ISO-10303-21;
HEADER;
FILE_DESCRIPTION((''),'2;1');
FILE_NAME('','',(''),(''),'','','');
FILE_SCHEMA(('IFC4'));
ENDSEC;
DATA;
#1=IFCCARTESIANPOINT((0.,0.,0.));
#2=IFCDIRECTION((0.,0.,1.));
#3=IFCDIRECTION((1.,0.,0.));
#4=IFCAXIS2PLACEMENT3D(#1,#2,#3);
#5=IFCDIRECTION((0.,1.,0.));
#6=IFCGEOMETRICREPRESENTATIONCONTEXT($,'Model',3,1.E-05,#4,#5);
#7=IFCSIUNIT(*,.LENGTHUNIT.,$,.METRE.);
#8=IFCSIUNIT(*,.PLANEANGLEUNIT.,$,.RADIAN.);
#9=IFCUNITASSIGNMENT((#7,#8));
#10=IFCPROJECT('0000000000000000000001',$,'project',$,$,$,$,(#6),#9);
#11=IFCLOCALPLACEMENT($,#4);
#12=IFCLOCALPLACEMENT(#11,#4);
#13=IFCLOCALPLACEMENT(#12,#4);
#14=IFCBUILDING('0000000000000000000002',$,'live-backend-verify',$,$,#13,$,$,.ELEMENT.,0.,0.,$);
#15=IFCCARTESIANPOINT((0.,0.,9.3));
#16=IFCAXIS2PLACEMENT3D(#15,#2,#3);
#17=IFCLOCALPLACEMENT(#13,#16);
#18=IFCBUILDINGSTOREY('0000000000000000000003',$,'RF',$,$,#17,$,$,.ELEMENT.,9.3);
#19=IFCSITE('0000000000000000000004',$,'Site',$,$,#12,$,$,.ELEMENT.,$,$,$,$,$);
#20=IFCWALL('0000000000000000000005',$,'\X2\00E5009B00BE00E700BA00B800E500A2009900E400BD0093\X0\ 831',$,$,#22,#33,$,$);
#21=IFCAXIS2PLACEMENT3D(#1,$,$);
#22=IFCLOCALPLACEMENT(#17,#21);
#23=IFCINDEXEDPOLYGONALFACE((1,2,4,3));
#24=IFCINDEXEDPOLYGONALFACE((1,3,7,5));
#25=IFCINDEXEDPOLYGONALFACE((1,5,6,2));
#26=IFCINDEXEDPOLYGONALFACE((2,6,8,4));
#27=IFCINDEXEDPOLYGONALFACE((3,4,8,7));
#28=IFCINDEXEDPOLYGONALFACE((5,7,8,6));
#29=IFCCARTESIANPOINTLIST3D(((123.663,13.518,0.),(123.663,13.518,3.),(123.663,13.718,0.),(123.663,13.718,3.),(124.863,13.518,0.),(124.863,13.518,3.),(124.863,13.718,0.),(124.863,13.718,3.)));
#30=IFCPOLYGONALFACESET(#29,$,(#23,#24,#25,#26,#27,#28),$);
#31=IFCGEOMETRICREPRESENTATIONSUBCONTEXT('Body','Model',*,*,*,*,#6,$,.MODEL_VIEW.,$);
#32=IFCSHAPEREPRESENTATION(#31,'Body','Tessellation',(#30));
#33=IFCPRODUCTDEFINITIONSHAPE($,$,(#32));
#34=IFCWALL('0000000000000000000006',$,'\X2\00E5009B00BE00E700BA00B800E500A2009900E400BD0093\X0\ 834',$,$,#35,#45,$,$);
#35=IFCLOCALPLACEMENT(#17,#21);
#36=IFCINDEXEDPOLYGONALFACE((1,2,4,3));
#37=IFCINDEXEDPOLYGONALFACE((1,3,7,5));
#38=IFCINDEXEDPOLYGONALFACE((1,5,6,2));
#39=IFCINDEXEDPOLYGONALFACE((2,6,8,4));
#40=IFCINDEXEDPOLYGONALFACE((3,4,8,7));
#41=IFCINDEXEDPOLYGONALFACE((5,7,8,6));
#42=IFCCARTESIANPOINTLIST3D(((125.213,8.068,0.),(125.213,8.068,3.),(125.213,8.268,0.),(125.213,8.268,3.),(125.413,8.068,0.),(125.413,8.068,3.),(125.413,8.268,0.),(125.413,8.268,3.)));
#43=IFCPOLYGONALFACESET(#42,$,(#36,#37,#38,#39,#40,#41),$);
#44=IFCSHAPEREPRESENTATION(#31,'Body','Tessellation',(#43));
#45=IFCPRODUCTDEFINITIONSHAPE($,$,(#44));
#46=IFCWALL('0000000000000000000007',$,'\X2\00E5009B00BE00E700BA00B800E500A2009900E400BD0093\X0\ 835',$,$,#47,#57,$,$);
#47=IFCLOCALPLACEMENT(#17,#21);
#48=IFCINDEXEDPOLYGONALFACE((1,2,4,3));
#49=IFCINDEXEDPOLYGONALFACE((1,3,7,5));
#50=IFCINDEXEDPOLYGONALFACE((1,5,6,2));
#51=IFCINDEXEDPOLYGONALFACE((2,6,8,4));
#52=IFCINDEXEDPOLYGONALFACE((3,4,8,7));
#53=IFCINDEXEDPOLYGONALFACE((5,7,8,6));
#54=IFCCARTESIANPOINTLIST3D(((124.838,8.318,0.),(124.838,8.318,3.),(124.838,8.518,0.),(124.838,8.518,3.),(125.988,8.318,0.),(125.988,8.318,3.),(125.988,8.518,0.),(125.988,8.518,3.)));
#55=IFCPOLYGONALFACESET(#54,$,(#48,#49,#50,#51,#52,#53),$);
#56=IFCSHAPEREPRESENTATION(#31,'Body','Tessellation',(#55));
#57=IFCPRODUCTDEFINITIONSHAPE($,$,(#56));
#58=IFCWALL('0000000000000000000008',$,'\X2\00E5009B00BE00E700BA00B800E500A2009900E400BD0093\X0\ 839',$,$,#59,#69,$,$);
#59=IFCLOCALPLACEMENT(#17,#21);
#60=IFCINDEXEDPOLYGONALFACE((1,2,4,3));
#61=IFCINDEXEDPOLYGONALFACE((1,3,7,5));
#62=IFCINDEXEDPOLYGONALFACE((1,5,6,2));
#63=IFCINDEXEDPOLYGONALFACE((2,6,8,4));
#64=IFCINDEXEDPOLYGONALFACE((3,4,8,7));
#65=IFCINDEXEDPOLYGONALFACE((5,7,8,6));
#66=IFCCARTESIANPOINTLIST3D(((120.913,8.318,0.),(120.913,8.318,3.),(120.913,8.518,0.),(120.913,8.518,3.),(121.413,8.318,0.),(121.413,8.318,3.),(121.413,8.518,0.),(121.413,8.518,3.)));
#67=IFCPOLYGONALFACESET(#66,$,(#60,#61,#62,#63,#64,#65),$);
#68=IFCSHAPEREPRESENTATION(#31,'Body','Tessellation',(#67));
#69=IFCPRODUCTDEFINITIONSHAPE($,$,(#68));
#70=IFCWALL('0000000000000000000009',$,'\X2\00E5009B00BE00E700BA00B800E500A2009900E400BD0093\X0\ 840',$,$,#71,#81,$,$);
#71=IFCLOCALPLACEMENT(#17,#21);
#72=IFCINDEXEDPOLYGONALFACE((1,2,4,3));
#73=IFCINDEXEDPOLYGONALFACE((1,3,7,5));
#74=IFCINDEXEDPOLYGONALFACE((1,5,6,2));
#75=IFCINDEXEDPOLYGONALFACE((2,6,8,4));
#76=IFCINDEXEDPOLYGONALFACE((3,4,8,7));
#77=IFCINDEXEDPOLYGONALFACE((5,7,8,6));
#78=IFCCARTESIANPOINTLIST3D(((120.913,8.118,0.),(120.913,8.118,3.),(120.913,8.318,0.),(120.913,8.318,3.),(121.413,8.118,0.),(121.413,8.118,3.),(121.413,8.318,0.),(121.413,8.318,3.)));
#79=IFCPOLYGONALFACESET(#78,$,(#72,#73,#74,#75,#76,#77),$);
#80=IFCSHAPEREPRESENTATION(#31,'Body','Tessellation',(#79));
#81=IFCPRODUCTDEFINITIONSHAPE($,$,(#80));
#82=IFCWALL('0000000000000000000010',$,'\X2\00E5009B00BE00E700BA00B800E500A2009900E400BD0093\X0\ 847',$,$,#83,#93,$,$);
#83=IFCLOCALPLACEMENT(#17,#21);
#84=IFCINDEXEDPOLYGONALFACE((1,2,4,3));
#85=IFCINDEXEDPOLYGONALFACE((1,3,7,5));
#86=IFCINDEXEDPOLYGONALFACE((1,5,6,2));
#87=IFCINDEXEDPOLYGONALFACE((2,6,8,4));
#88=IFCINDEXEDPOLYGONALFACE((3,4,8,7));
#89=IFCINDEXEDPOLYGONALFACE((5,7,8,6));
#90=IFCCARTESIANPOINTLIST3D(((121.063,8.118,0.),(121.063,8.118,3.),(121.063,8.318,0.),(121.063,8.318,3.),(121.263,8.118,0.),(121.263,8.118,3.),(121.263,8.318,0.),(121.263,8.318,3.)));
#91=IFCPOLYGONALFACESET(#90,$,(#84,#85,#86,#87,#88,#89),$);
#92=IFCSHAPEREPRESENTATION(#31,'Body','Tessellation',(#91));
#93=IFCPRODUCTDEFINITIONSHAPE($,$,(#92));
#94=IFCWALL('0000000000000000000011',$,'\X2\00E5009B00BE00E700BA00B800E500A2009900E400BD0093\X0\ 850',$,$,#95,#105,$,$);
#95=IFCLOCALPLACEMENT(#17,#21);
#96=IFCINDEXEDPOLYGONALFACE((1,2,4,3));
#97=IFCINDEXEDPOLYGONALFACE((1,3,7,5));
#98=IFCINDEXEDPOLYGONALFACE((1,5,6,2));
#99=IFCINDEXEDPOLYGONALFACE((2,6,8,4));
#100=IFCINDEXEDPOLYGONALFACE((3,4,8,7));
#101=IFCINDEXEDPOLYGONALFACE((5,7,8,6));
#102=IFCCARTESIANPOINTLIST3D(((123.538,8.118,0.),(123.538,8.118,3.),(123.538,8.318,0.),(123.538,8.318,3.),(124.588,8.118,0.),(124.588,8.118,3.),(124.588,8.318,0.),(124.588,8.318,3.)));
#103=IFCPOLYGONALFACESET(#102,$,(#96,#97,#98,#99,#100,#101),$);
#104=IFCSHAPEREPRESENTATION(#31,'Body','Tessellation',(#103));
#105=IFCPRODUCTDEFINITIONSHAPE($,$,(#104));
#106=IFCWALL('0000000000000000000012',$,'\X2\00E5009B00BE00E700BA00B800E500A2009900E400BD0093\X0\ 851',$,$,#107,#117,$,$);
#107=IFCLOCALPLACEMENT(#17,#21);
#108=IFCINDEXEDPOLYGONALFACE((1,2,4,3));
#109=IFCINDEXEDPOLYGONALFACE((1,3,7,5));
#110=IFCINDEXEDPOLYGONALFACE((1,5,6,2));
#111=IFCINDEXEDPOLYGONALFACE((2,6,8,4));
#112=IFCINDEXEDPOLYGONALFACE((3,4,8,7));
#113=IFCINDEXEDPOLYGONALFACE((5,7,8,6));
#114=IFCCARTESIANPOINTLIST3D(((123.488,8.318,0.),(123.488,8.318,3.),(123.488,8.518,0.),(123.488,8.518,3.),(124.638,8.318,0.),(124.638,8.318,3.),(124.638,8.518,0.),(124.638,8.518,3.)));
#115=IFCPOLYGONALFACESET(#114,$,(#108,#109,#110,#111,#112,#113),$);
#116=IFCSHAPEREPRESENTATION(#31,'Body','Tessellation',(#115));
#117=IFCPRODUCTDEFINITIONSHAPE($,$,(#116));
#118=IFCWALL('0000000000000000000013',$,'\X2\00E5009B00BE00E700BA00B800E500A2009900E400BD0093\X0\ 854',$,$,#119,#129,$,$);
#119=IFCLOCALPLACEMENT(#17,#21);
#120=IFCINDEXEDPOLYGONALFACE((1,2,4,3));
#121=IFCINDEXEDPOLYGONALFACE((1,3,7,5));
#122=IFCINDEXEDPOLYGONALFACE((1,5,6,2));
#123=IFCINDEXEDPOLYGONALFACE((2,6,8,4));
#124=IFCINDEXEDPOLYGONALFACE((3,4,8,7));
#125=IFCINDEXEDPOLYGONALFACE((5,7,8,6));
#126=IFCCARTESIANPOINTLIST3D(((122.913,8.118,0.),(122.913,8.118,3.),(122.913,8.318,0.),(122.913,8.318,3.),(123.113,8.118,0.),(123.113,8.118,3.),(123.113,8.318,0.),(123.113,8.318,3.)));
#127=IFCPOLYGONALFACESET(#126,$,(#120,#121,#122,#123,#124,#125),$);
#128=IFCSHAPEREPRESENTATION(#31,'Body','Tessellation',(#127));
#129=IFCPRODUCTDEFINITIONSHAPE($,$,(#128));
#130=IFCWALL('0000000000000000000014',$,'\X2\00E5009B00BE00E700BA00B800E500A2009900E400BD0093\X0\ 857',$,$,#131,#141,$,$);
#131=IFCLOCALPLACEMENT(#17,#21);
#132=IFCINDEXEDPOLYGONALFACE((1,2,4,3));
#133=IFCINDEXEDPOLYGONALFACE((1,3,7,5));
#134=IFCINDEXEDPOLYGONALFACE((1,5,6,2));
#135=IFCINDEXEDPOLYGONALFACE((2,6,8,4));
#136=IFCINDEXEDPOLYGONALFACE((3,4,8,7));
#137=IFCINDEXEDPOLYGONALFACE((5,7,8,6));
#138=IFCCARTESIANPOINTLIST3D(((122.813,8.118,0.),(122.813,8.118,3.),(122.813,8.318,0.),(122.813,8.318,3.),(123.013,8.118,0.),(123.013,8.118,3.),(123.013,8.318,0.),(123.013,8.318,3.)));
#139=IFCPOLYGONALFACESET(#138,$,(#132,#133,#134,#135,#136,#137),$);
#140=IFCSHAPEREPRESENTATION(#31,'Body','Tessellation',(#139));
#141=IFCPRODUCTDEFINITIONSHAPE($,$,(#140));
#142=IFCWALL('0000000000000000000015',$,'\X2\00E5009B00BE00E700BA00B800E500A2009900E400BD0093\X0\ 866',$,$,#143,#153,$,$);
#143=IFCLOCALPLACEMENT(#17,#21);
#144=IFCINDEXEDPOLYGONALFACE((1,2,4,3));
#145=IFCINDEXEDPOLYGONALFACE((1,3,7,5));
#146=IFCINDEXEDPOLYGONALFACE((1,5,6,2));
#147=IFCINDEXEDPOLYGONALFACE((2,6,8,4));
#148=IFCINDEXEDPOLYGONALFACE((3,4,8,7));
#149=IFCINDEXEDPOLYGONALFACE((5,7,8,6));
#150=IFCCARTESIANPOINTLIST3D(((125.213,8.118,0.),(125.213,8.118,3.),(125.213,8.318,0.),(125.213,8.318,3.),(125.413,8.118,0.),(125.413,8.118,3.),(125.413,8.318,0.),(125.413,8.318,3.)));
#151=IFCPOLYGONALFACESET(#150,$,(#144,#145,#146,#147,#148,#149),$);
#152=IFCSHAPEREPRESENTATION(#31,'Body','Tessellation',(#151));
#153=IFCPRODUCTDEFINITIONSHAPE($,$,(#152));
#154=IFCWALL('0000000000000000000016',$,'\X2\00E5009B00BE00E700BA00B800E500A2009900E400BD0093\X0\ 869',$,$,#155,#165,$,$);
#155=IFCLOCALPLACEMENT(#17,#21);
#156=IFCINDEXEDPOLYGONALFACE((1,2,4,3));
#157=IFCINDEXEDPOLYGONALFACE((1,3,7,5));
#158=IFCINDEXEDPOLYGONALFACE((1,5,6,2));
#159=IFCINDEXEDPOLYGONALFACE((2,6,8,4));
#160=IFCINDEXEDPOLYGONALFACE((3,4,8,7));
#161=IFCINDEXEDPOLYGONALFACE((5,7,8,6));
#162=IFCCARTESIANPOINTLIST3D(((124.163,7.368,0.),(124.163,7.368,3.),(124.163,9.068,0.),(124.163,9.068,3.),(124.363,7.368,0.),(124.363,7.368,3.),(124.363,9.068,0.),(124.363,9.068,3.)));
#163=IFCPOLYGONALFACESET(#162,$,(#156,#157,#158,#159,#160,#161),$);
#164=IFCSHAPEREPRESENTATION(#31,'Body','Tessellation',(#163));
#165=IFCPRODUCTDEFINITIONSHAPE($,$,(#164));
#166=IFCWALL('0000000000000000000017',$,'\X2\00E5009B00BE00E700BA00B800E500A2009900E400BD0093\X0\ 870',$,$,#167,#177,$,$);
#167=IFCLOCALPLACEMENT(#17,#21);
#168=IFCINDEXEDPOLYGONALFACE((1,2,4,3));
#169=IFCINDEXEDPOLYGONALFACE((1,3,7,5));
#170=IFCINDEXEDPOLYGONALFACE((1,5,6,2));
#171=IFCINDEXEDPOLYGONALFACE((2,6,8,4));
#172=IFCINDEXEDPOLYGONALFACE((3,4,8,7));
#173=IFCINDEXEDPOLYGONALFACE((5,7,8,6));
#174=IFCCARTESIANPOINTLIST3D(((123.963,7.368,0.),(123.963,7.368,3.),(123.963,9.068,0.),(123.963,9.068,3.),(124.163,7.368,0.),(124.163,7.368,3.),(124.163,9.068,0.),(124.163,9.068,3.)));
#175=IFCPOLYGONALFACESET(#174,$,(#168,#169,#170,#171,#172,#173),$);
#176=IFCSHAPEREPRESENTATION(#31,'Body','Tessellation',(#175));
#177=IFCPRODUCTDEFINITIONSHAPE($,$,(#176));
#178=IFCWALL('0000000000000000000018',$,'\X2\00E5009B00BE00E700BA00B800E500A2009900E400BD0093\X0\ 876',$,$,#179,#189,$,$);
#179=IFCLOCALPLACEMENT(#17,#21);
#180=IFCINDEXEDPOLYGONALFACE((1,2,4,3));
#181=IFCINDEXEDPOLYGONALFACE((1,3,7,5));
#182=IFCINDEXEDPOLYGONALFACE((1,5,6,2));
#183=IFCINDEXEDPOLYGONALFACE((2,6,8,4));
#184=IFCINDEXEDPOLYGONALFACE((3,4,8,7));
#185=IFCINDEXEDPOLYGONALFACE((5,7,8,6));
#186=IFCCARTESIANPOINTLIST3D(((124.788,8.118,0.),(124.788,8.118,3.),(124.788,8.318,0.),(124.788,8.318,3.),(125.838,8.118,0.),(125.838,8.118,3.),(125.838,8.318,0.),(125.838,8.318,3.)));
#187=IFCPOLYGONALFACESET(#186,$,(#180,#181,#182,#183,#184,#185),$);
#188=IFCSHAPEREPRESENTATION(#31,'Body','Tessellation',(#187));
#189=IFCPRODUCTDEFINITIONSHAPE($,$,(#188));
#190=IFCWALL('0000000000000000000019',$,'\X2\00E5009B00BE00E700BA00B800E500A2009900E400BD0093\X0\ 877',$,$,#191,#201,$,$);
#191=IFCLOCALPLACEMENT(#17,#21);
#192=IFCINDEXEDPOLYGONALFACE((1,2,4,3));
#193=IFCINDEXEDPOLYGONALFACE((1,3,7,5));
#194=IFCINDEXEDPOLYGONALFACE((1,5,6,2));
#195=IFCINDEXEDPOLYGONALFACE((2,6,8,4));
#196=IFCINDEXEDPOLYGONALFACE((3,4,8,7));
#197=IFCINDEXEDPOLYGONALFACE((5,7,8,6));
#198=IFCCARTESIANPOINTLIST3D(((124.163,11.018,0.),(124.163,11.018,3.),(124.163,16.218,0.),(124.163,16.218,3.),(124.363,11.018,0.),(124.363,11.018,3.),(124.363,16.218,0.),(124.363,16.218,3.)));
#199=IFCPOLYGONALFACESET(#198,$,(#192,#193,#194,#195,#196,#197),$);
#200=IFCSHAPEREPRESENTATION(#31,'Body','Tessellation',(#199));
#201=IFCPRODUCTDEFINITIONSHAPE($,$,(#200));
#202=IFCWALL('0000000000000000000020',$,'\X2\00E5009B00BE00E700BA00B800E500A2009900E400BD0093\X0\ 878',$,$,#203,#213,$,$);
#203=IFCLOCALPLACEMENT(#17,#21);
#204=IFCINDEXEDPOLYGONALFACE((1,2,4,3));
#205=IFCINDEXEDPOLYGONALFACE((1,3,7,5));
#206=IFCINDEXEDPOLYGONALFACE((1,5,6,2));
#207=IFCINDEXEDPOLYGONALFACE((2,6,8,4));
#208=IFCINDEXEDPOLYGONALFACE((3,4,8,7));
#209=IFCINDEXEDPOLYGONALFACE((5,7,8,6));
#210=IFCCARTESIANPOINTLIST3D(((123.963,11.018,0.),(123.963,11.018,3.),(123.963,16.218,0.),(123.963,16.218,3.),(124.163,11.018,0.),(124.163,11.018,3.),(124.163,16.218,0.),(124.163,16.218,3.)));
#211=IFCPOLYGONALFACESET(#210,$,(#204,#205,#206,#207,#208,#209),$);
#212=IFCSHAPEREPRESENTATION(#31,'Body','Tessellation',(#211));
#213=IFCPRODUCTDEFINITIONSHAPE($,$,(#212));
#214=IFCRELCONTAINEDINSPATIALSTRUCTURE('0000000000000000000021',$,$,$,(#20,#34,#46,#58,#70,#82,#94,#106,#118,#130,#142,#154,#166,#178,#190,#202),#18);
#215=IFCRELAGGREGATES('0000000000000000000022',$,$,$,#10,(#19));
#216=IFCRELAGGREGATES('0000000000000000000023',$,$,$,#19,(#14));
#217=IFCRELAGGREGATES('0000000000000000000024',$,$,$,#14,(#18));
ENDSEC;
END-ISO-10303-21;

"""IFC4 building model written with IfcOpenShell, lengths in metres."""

from ifc_helpers import new_model, si_unit, direction, frame, frame_2d, origin_with_axes, place, context, subcontext, project, spatial, rectangle, extrude, element, save


model = new_model("IFC4")

# Units and contexts
model_context = context("Model", 3, precision=1e-05, world=origin_with_axes(), true_north=direction((0.0, 1.0, 0.0)))
body_context = subcontext(model_context, "Body", "Model", "MODEL_VIEW")
ifc_project = project(units=[si_unit("LENGTHUNIT", "METRE"), si_unit("PLANEANGLEUNIT", "RADIAN")], contexts=[model_context])

# Site, building, storey
placement = place(None, origin_with_axes())
site_placement = place(placement, origin_with_axes())
site = spatial("IfcSite", under=ifc_project, at=site_placement, Name="Site", CompositionType="ELEMENT")
building_placement = place(site_placement, origin_with_axes())
building = spatial("IfcBuilding", under=site, at=building_placement, Name="live-backend-verify", CompositionType="ELEMENT", ElevationOfRefHeight=0.0, ElevationOfTerrain=0.0)
storey_placement = place(building_placement, frame((0.0, 0.0, 9.3), z_axis=(0.0, 0.0, 1.0), x_axis=(1.0, 0.0, 0.0)))
storey = spatial("IfcBuildingStorey", under=building, at=storey_placement, Name="RF", CompositionType="ELEMENT", Elevation=9.3)

# Walls
wall_1_placement = place(storey_placement, frame((124.263, 13.618, 0.0), z_axis=(0.0, 0.0, 1.0), x_axis=(1.0, 0.0, 0.0)))
element("IfcWall", 1, at=wall_1_placement, inside=storey, Name="å\u009b¾çº¸å¢\u0099ä½\u0093 831", context=body_context, shape_type="SweptSolid", body=[
    extrude(rectangle(XDim=1.2, YDim=0.2, at=frame_2d((0.0, 0.0), x_axis=(1.0, 0.0, 0.0))), frame((0.0, 0.0, 0.0), z_axis=(0.0, 0.0, 1.0)), (0.0, 0.0, 1.0), 3.0),
])
wall_2_placement = place(storey_placement, frame((125.313, 8.168, 0.0), z_axis=(0.0, 0.0, 1.0), x_axis=(1.0, 0.0, 0.0)))
element("IfcWall", 2, at=wall_2_placement, inside=storey, Name="å\u009b¾çº¸å¢\u0099ä½\u0093 834", context=body_context, shape_type="SweptSolid", body=[
    extrude(rectangle(XDim=0.2, YDim=0.2, at=frame_2d((0.0, 0.0), x_axis=(1.0, 0.0, 0.0))), frame((0.0, 0.0, 0.0), z_axis=(0.0, 0.0, 1.0)), (0.0, 0.0, 1.0), 3.0),
])
wall_3_placement = place(storey_placement, frame((125.413, 8.418, 0.0), z_axis=(0.0, 0.0, 1.0), x_axis=(-1.0, 0.0, 0.0)))
element("IfcWall", 3, at=wall_3_placement, inside=storey, Name="å\u009b¾çº¸å¢\u0099ä½\u0093 835", context=body_context, shape_type="SweptSolid", body=[
    extrude(rectangle(XDim=1.15, YDim=0.2, at=frame_2d((0.0, 0.0), x_axis=(1.0, 0.0, 0.0))), frame((0.0, 0.0, 0.0), z_axis=(0.0, 0.0, 1.0)), (0.0, 0.0, 1.0), 3.0),
])
for number, where, z_axis, x_axis, name in (
    (4, (121.163, 8.418, 0.0), (0.0, 0.0, 1.0), (-1.0, 0.0, 0.0), "å\u009b¾çº¸å¢\u0099ä½\u0093 839"),
    (5, (121.163, 8.218, 0.0), (0.0, 0.0, 1.0), (-1.0, 0.0, 0.0), "å\u009b¾çº¸å¢\u0099ä½\u0093 840"),
):
    element("IfcWall", number, at=place(storey_placement, frame(where, z_axis=z_axis, x_axis=x_axis)), inside=storey, Name=name, context=body_context, shape_type="SweptSolid", body=[
        extrude(rectangle(XDim=0.5, YDim=0.2, at=frame_2d((0.0, 0.0), x_axis=(1.0, 0.0, 0.0))), frame((0.0, 0.0, 0.0), z_axis=(0.0, 0.0, 1.0)), (0.0, 0.0, 1.0), 3.0),
    ])
wall_4_placement = place(storey_placement, frame((121.163, 8.218, 0.0), z_axis=(0.0, 0.0, 1.0), x_axis=(0.0, 1.0, 0.0)))
element("IfcWall", 6, at=wall_4_placement, inside=storey, Name="å\u009b¾çº¸å¢\u0099ä½\u0093 847", context=body_context, shape_type="SweptSolid", body=[
    extrude(rectangle(XDim=0.2, YDim=0.2, at=frame_2d((0.0, 0.0), x_axis=(1.0, 0.0, 0.0))), frame((0.0, 0.0, 0.0), z_axis=(0.0, 0.0, 1.0)), (0.0, 0.0, 1.0), 3.0),
])
wall_5_placement = place(storey_placement, frame((124.063, 8.218, 0.0), z_axis=(0.0, 0.0, 1.0), x_axis=(-1.0, 0.0, 0.0)))
element("IfcWall", 7, at=wall_5_placement, inside=storey, Name="å\u009b¾çº¸å¢\u0099ä½\u0093 850", context=body_context, shape_type="SweptSolid", body=[
    extrude(rectangle(XDim=1.05, YDim=0.2, at=frame_2d((0.0, 0.0), x_axis=(1.0, 0.0, 0.0))), frame((0.0, 0.0, 0.0), z_axis=(0.0, 0.0, 1.0)), (0.0, 0.0, 1.0), 3.0),
])
wall_6_placement = place(storey_placement, frame((124.063, 8.418, 0.0), z_axis=(0.0, 0.0, 1.0), x_axis=(-1.0, 0.0, 0.0)))
element("IfcWall", 8, at=wall_6_placement, inside=storey, Name="å\u009b¾çº¸å¢\u0099ä½\u0093 851", context=body_context, shape_type="SweptSolid", body=[
    extrude(rectangle(XDim=1.15, YDim=0.2, at=frame_2d((0.0, 0.0), x_axis=(1.0, 0.0, 0.0))), frame((0.0, 0.0, 0.0), z_axis=(0.0, 0.0, 1.0)), (0.0, 0.0, 1.0), 3.0),
])
for number, where, z_axis, x_axis, name in (
    (9, (123.013, 8.218, 0.0), (0.0, 0.0, 1.0), (0.0, -1.0, 0.0), "å\u009b¾çº¸å¢\u0099ä½\u0093 854"),
    (10, (122.913, 8.218, 0.0), (0.0, 0.0, 1.0), (0.0, 1.0, 0.0), "å\u009b¾çº¸å¢\u0099ä½\u0093 857"),
    (11, (125.313, 8.218, 0.0), (0.0, 0.0, 1.0), (0.0, -1.0, 0.0), "å\u009b¾çº¸å¢\u0099ä½\u0093 866"),
):
    element("IfcWall", number, at=place(storey_placement, frame(where, z_axis=z_axis, x_axis=x_axis)), inside=storey, Name=name, context=body_context, shape_type="SweptSolid", body=[
        extrude(rectangle(XDim=0.2, YDim=0.2, at=frame_2d((0.0, 0.0), x_axis=(1.0, 0.0, 0.0))), frame((0.0, 0.0, 0.0), z_axis=(0.0, 0.0, 1.0)), (0.0, 0.0, 1.0), 3.0),
    ])
for number, where, z_axis, x_axis, name in (
    (12, (124.263, 8.218, 0.0), (0.0, 0.0, 1.0), (0.0, -1.0, 0.0), "å\u009b¾çº¸å¢\u0099ä½\u0093 869"),
    (13, (124.063, 8.218, 0.0), (0.0, 0.0, 1.0), (0.0, -1.0, 0.0), "å\u009b¾çº¸å¢\u0099ä½\u0093 870"),
):
    element("IfcWall", number, at=place(storey_placement, frame(where, z_axis=z_axis, x_axis=x_axis)), inside=storey, Name=name, context=body_context, shape_type="SweptSolid", body=[
        extrude(rectangle(XDim=1.7, YDim=0.2, at=frame_2d((0.0, 0.0), x_axis=(1.0, 0.0, 0.0))), frame((0.0, 0.0, 0.0), z_axis=(0.0, 0.0, 1.0)), (0.0, 0.0, 1.0), 3.0),
    ])
wall_7_placement = place(storey_placement, frame((125.313, 8.218, 0.0), z_axis=(0.0, 0.0, 1.0), x_axis=(-1.0, 0.0, 0.0)))
element("IfcWall", 14, at=wall_7_placement, inside=storey, Name="å\u009b¾çº¸å¢\u0099ä½\u0093 876", context=body_context, shape_type="SweptSolid", body=[
    extrude(rectangle(XDim=1.05, YDim=0.2, at=frame_2d((0.0, 0.0), x_axis=(1.0, 0.0, 0.0))), frame((0.0, 0.0, 0.0), z_axis=(0.0, 0.0, 1.0)), (0.0, 0.0, 1.0), 3.0),
])
for number, where, z_axis, x_axis, name in (
    (15, (124.263, 13.618, 0.0), (0.0, 0.0, 1.0), (0.0, -1.0, 0.0), "å\u009b¾çº¸å¢\u0099ä½\u0093 877"),
    (16, (124.063, 13.618, 0.0), (0.0, 0.0, 1.0), (0.0, -1.0, 0.0), "å\u009b¾çº¸å¢\u0099ä½\u0093 878"),
):
    element("IfcWall", number, at=place(storey_placement, frame(where, z_axis=z_axis, x_axis=x_axis)), inside=storey, Name=name, context=body_context, shape_type="SweptSolid", body=[
        extrude(rectangle(XDim=5.2, YDim=0.2, at=frame_2d((0.0, 0.0), x_axis=(1.0, 0.0, 0.0))), frame((0.0, 0.0, 0.0), z_axis=(0.0, 0.0, 1.0)), (0.0, 0.0, 1.0), 3.0),
    ])

save(model, "model.ifc")
